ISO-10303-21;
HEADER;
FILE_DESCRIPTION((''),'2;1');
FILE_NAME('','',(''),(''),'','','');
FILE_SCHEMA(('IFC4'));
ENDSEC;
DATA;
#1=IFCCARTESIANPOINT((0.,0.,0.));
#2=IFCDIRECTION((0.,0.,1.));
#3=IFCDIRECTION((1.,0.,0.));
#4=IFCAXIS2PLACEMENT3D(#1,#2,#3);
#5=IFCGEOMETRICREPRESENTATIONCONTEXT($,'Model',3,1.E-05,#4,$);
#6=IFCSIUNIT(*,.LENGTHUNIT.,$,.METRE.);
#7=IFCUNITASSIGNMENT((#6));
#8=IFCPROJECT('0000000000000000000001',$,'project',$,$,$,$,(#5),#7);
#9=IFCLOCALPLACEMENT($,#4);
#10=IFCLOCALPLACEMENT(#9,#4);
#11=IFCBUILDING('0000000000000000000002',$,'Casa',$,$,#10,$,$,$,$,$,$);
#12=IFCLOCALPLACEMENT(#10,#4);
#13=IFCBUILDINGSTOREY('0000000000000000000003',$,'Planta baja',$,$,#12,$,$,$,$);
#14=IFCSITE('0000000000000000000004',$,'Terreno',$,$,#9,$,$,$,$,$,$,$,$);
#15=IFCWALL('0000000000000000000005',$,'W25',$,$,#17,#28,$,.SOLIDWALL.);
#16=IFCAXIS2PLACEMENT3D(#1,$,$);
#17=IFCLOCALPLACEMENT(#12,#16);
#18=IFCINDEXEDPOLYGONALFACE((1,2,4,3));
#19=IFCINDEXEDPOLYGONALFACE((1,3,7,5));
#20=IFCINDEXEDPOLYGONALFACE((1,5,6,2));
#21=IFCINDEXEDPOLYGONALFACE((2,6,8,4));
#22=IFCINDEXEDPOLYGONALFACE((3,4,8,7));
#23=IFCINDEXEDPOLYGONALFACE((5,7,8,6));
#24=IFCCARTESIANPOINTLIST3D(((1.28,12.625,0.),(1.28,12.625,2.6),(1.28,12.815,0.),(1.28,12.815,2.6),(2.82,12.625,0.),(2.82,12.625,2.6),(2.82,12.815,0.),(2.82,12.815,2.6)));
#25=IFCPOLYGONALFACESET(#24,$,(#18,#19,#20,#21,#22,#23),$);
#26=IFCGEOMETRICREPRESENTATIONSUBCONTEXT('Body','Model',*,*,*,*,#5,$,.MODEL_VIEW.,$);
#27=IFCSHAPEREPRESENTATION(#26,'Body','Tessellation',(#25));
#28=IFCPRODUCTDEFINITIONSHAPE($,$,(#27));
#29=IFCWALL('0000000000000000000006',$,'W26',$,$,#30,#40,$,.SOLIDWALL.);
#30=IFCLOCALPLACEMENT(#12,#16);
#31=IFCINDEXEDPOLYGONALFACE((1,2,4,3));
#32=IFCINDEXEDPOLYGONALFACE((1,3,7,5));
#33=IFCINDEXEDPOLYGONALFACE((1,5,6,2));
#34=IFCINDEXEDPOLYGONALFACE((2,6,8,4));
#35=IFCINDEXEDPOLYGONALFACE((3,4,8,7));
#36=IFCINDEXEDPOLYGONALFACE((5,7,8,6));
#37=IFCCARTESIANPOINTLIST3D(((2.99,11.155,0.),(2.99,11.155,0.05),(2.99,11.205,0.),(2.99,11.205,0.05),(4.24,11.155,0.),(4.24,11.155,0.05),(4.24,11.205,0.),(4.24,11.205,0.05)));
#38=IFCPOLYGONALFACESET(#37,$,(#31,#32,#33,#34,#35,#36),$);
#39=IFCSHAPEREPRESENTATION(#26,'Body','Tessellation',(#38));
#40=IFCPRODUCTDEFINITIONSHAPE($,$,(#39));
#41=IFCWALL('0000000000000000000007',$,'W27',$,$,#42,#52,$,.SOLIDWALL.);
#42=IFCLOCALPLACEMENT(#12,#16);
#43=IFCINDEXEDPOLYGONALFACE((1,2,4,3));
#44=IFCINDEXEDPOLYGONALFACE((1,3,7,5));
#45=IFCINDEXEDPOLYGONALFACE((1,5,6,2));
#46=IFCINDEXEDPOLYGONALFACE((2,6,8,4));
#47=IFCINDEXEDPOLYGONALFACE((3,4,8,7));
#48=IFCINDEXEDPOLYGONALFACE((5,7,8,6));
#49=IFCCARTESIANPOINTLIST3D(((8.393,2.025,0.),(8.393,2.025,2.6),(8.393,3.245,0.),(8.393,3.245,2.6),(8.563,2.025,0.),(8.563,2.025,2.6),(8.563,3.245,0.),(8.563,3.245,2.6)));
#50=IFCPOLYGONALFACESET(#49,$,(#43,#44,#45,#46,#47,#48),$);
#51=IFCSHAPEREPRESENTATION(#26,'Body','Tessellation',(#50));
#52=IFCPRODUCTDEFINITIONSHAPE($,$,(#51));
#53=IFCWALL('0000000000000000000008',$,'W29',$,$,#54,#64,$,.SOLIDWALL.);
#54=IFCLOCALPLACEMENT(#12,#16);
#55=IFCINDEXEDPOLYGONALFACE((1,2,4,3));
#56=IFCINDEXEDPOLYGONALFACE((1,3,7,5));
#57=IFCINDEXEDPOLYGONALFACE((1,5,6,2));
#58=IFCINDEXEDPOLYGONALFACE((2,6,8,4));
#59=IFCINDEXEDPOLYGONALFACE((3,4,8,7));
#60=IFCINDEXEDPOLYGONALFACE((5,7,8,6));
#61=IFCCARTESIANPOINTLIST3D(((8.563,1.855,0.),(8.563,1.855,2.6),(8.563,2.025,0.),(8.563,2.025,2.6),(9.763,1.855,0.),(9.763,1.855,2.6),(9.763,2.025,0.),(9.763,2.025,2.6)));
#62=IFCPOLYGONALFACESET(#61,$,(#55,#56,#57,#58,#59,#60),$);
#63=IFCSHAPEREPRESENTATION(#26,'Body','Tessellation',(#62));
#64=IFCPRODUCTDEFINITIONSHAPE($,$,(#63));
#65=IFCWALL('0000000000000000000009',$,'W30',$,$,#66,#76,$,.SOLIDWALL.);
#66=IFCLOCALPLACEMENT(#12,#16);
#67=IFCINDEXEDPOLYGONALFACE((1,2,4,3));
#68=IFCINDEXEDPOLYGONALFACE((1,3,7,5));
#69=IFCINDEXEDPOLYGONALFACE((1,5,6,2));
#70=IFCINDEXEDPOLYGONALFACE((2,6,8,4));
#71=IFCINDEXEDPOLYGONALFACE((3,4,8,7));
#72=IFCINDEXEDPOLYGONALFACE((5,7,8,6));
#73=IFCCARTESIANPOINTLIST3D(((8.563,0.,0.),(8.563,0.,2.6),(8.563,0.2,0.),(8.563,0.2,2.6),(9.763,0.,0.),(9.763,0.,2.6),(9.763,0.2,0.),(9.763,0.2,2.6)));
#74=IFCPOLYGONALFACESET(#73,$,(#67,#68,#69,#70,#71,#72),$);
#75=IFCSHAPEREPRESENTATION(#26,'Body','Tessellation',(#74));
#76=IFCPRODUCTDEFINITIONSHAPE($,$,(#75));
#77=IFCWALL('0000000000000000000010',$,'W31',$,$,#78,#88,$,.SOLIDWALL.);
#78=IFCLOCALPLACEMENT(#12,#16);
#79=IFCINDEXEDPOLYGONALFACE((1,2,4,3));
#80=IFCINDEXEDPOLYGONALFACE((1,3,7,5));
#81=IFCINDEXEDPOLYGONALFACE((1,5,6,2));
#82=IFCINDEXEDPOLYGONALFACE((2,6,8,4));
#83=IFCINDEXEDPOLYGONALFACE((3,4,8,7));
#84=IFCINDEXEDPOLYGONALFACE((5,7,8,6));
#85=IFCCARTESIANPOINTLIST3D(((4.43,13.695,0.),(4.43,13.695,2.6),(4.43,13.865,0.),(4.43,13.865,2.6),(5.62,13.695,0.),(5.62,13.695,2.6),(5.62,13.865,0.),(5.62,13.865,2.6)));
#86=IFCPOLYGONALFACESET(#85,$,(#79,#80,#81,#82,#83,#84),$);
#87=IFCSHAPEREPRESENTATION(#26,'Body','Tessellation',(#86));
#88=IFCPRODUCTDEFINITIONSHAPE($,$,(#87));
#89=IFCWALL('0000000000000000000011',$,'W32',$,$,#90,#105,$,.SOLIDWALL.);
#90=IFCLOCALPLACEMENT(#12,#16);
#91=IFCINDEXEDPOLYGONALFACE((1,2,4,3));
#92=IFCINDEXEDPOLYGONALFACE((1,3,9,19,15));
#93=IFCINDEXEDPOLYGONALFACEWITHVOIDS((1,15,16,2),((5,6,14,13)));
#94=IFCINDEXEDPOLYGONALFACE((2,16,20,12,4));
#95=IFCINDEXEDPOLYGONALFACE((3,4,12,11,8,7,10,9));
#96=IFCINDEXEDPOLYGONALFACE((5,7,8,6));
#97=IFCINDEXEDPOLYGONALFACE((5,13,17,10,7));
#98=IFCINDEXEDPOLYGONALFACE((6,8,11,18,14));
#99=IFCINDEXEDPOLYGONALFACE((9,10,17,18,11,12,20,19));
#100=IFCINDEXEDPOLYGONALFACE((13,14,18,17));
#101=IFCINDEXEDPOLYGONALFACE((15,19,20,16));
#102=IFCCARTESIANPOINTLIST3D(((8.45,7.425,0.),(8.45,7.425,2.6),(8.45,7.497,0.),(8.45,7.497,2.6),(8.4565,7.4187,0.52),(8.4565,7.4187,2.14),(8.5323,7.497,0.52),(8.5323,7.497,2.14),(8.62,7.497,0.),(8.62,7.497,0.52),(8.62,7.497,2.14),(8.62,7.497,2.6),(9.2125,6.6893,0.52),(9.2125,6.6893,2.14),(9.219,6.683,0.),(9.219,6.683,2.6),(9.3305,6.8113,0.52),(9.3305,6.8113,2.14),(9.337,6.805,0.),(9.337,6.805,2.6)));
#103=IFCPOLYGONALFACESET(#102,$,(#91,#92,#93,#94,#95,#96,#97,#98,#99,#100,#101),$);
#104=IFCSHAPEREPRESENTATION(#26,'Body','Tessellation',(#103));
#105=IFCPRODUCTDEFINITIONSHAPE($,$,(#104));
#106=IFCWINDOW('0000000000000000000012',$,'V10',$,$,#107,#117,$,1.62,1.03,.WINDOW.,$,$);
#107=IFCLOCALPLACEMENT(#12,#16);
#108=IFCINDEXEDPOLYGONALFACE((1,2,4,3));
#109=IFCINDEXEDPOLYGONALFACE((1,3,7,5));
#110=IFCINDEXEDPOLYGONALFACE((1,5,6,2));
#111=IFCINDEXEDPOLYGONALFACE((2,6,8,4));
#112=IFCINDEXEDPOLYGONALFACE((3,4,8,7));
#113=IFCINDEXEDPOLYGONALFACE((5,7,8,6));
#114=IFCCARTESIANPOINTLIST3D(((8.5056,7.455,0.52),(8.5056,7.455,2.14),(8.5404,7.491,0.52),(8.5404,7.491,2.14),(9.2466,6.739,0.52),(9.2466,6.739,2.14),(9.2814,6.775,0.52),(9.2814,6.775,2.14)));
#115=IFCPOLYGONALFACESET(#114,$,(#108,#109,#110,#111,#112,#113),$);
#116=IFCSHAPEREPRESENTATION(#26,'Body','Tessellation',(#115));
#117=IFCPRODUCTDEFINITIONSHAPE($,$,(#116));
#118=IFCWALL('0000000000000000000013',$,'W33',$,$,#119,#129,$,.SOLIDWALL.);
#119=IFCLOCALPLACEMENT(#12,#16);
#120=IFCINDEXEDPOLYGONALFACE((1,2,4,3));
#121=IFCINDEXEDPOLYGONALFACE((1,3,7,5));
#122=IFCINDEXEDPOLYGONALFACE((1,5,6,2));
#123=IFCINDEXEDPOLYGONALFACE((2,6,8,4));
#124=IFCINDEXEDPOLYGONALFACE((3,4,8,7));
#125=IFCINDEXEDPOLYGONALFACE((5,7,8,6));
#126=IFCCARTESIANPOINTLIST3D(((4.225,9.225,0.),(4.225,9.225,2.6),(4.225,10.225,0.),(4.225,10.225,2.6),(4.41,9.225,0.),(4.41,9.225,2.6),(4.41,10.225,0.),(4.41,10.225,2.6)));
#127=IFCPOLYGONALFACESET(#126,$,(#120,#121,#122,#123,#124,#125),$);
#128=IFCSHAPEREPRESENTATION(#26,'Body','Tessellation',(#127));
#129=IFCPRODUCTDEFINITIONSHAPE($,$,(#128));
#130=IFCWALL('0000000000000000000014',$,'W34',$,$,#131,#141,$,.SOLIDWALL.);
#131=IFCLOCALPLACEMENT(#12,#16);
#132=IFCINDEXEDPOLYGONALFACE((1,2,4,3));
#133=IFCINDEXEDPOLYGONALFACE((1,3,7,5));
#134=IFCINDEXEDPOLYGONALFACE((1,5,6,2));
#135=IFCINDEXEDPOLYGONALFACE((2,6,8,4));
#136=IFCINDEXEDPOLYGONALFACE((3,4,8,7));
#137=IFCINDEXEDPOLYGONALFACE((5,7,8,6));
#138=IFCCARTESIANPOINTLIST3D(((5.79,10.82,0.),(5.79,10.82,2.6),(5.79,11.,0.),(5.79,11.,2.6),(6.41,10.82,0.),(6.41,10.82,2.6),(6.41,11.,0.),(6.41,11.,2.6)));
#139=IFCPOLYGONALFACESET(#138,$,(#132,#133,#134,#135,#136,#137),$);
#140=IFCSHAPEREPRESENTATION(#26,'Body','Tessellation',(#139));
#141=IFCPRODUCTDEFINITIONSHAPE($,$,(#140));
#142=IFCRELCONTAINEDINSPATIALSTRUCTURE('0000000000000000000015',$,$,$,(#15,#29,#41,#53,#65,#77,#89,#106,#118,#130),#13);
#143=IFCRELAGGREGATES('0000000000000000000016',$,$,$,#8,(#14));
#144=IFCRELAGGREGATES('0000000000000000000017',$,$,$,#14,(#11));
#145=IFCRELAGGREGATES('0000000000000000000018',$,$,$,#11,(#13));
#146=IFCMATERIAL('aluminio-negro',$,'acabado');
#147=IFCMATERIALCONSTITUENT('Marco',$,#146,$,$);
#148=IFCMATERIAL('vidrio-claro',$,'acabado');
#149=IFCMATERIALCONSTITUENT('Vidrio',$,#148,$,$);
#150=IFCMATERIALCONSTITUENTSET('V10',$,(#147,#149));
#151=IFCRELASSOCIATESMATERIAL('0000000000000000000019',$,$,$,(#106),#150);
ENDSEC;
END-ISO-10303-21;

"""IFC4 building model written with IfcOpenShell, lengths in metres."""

from ifc_helpers import new_model, si_unit, frame, origin_with_axes, place, context, subcontext, project, spatial, line, indexed_curve, outline, extrude, material, constituent, constituent_set, element, fill, save


model = new_model("IFC4")

# Units and contexts
model_context = context("Model", 3, precision=1e-05, world=origin_with_axes())
body_context = subcontext(model_context, "Body", "Model", "MODEL_VIEW")
ifc_project = project(units=[si_unit("LENGTHUNIT", "METRE")], contexts=[model_context])

# Site, building, storey
site_placement = place(None, origin_with_axes())
site = spatial("IfcSite", under=ifc_project, at=site_placement, Name="Terreno")
building_placement = place(site_placement, origin_with_axes())
building = spatial("IfcBuilding", under=site, at=building_placement, Name="Casa")
storey_placement = place(building_placement, origin_with_axes())
storey = spatial("IfcBuildingStorey", under=building, at=storey_placement, Name="Planta baja")

# Shared definitions
ifc_material_1 = material(Name="aluminio-negro", Category="acabado")
ifc_material_2 = material(Name="vidrio-claro", Category="acabado")

# Walls
wall_1_placement = place(storey_placement, origin_with_axes())
element("IfcWall", 1, at=wall_1_placement, inside=storey, Name="W25", PredefinedType="SOLIDWALL", context=body_context, shape_type="SweptSolid", body=[
    extrude(outline(indexed_curve([(2.82, 12.815), (2.82, 12.625), (1.28, 12.625), (1.28, 12.815)], segments=[line(1, 2, 3, 4, 1)])), origin_with_axes(), (0.0, 0.0, 1.0), 2.6),
])
wall_2_placement = place(storey_placement, origin_with_axes())
element("IfcWall", 2, at=wall_2_placement, inside=storey, Name="W26", PredefinedType="SOLIDWALL", context=body_context, shape_type="SweptSolid", body=[
    extrude(outline(indexed_curve([(4.24, 11.205), (4.24, 11.155), (2.99, 11.155), (2.99, 11.205)], segments=[line(1, 2, 3, 4, 1)])), origin_with_axes(), (0.0, 0.0, 1.0), 0.05),
])
wall_3_placement = place(storey_placement, origin_with_axes())
element("IfcWall", 3, at=wall_3_placement, inside=storey, Name="W27", PredefinedType="SOLIDWALL", context=body_context, shape_type="SweptSolid", body=[
    extrude(outline(indexed_curve([(8.563, 2.025), (8.393, 2.025), (8.393, 3.245), (8.563, 3.245)], segments=[line(1, 2, 3, 4, 1)])), origin_with_axes(), (0.0, 0.0, 1.0), 2.6),
])
wall_4_placement = place(storey_placement, origin_with_axes())
element("IfcWall", 4, at=wall_4_placement, inside=storey, Name="W29", PredefinedType="SOLIDWALL", context=body_context, shape_type="SweptSolid", body=[
    extrude(outline(indexed_curve([(9.763, 1.855), (8.563, 1.855), (8.563, 2.025), (9.763, 2.025)], segments=[line(1, 2, 3, 4, 1)])), origin_with_axes(), (0.0, 0.0, 1.0), 2.6),
])
wall_5_placement = place(storey_placement, origin_with_axes())
element("IfcWall", 5, at=wall_5_placement, inside=storey, Name="W30", PredefinedType="SOLIDWALL", context=body_context, shape_type="SweptSolid", body=[
    extrude(outline(indexed_curve([(8.563, 0.2), (9.763, 0.2), (9.763, 0.0), (8.563, 0.0)], segments=[line(1, 2, 3, 4, 1)])), origin_with_axes(), (0.0, 0.0, 1.0), 2.6),
])
wall_6_placement = place(storey_placement, origin_with_axes())
element("IfcWall", 6, at=wall_6_placement, inside=storey, Name="W31", PredefinedType="SOLIDWALL", context=body_context, shape_type="SweptSolid", body=[
    extrude(outline(indexed_curve([(5.62, 13.695), (4.43, 13.695), (4.43, 13.865), (5.62, 13.865)], segments=[line(1, 2, 3, 4, 1)])), origin_with_axes(), (0.0, 0.0, 1.0), 2.6),
])

# Wall, opening, window
wall_7_placement = place(storey_placement, origin_with_axes())
wall_7 = element("IfcWall", 7, at=wall_7_placement, inside=storey, Name="W32", PredefinedType="SOLIDWALL", context=body_context, shape_type="SweptSolid", body=[
    extrude(outline(indexed_curve([(8.62, 7.497), (9.337, 6.805), (9.219, 6.683), (8.45, 7.425), (8.45, 7.497)], segments=[line(1, 2, 3, 4, 5, 1)])), origin_with_axes(), (0.0, 0.0, 1.0), 2.6),
])
opening_1_placement = place(wall_7_placement, origin_with_axes())
opening_1 = element("IfcOpeningElement", 8, at=opening_1_placement, cuts=wall_7, PredefinedType="OPENING", context=body_context, shape_type="SweptSolid", body=[
    extrude(outline(indexed_curve([(8.4499, 7.4118), (9.2052, 6.6819), (9.3371, 6.8182), (8.5818, 7.5481)], segments=[line(1, 2, 3, 4, 1)])), frame((0.0, 0.0, 0.52), z_axis=(0.0, 0.0, 1.0), x_axis=(1.0, 0.0, 0.0)), (0.0, 0.0, 1.0), 1.62),
])
ifc_constituent_1 = constituent(ifc_material_1, Name="Marco")
ifc_constituent_2 = constituent(ifc_material_2, Name="Vidrio")
ifc_constituent_set_1 = constituent_set(constituents=[ifc_constituent_1, ifc_constituent_2], Name="V10")
window_1_placement = place(opening_1_placement, origin_with_axes())
window_1 = element("IfcWindow", 9, at=window_1_placement, inside=storey, material=ifc_constituent_set_1, Name="V10", OverallHeight=1.62, OverallWidth=1.03, PredefinedType="WINDOW", context=body_context, shape_type="SweptSolid", body=[
    extrude(outline(indexed_curve([(8.5056, 7.455), (9.2466, 6.739), (9.2814, 6.775), (8.5404, 7.491)], segments=[line(1, 2, 3, 4, 1)])), frame((0.0, 0.0, 0.52), z_axis=(0.0, 0.0, 1.0), x_axis=(1.0, 0.0, 0.0)), (0.0, 0.0, 1.0), 1.62),
])
fill(opening_1, window_1)

# Walls
wall_8_placement = place(storey_placement, origin_with_axes())
element("IfcWall", 10, at=wall_8_placement, inside=storey, Name="W33", PredefinedType="SOLIDWALL", context=body_context, shape_type="SweptSolid", body=[
    extrude(outline(indexed_curve([(4.41, 9.225), (4.225, 9.225), (4.225, 10.225), (4.41, 10.225)], segments=[line(1, 2, 3, 4, 1)])), origin_with_axes(), (0.0, 0.0, 1.0), 2.6),
])
wall_9_placement = place(storey_placement, origin_with_axes())
element("IfcWall", 11, at=wall_9_placement, inside=storey, Name="W34", PredefinedType="SOLIDWALL", context=body_context, shape_type="SweptSolid", body=[
    extrude(outline(indexed_curve([(6.41, 11.0), (6.41, 10.82), (5.79, 10.82), (5.79, 11.0)], segments=[line(1, 2, 3, 4, 1)])), origin_with_axes(), (0.0, 0.0, 1.0), 2.6),
])

save(model, "model.ifc")
